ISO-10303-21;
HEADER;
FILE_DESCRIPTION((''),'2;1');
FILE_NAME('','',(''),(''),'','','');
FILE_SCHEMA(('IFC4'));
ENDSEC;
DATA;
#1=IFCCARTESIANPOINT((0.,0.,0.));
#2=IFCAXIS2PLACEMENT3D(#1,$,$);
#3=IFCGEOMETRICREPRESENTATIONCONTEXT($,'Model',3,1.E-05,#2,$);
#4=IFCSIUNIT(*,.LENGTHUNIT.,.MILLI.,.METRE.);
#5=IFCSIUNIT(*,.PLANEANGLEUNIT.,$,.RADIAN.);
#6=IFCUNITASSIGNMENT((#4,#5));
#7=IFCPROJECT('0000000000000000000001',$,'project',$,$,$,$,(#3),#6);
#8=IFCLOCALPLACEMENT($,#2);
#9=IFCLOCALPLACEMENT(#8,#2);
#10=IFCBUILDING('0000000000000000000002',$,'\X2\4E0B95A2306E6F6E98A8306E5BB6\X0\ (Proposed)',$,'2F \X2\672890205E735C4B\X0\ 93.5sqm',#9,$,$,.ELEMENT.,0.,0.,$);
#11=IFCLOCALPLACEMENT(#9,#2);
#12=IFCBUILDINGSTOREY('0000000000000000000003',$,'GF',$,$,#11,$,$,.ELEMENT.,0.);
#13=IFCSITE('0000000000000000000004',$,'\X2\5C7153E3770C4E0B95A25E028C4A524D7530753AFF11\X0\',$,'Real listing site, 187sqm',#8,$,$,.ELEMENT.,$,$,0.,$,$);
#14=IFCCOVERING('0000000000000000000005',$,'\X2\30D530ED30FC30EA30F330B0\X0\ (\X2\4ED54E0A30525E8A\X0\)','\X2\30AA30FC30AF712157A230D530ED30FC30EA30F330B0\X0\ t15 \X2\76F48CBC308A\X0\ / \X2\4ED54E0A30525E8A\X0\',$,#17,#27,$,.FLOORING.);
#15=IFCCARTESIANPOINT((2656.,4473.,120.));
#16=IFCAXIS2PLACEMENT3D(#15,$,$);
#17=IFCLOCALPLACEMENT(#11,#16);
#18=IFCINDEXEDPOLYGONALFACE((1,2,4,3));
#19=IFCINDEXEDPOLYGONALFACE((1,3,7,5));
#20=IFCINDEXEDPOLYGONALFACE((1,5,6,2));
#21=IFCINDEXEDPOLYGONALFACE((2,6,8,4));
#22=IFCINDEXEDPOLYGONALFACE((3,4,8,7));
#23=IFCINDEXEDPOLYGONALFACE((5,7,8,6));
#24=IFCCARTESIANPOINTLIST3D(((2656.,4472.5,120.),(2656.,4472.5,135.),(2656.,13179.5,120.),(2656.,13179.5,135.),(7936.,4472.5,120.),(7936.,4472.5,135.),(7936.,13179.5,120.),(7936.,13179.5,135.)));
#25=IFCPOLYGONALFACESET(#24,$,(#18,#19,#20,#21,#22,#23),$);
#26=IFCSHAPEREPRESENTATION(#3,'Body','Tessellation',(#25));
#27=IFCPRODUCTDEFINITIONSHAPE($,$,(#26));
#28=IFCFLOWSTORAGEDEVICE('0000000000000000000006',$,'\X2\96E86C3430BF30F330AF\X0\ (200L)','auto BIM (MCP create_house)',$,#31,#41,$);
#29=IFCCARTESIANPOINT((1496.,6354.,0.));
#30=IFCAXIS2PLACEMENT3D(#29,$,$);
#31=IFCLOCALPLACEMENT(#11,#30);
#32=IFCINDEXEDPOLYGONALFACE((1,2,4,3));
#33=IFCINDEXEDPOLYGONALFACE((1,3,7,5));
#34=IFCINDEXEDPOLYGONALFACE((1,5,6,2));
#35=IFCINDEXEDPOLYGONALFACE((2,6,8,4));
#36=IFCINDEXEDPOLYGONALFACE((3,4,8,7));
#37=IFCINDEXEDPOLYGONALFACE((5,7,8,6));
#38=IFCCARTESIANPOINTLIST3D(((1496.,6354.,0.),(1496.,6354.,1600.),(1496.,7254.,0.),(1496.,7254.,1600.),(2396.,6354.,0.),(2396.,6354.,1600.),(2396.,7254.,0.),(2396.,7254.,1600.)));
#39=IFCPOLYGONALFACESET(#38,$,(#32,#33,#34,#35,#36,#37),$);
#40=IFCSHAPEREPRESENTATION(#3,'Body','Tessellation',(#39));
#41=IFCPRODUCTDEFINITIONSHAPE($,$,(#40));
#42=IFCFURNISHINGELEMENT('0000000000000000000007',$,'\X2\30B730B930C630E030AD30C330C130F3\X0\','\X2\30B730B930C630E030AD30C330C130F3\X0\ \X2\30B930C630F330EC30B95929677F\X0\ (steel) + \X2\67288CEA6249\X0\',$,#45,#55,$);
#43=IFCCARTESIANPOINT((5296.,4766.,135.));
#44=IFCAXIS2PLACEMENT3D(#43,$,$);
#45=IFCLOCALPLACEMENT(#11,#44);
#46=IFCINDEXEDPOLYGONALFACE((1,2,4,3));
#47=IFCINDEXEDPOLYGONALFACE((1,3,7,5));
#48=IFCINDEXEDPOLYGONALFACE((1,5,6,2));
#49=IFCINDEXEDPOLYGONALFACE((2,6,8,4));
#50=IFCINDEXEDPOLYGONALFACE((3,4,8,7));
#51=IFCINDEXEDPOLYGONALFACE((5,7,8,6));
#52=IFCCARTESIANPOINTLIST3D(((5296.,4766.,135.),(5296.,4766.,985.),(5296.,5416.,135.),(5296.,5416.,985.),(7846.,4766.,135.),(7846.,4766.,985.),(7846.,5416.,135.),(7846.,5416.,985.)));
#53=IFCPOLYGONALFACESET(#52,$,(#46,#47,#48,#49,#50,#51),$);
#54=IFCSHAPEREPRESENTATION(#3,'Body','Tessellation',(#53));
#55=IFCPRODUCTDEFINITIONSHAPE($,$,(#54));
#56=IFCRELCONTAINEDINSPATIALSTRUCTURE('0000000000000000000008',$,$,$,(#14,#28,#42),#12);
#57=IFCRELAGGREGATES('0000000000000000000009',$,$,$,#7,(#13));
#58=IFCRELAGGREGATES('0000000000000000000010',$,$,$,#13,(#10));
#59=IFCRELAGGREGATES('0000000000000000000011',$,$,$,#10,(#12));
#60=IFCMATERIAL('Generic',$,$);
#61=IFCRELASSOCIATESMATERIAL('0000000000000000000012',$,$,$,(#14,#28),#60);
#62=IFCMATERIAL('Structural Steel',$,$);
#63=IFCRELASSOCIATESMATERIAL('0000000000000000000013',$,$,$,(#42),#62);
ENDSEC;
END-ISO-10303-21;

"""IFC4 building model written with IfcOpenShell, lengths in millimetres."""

from ifc_helpers import new_model, si_unit, frame, frame_2d, origin, place, context, project, spatial, rectangle, extrude, material, element, save


model = new_model("IFC4")

# Units and contexts
model_context = context("Model", 3, precision=1e-05, world=origin())
ifc_project = project(units=[si_unit("LENGTHUNIT", "METRE", prefix="MILLI"), si_unit("PLANEANGLEUNIT", "RADIAN")], contexts=[model_context])

# Site, building, storey
site_placement = place(None, origin())
site = spatial("IfcSite", under=ifc_project, at=site_placement, Name="山口県下関市豊前田町１", ObjectType="Real listing site, 187sqm", CompositionType="ELEMENT", RefElevation=0.0)
building_placement = place(site_placement, origin())
building = spatial("IfcBuilding", under=site, at=building_placement, Name="下関の潮風の家 (Proposed)", ObjectType="2F 木造平屋 93.5sqm", CompositionType="ELEMENT", ElevationOfRefHeight=0.0, ElevationOfTerrain=0.0)
storey_placement = place(building_placement, origin())
storey = spatial("IfcBuildingStorey", under=building, at=storey_placement, Name="GF", CompositionType="ELEMENT", Elevation=0.0)

# Covering
ifc_material_1 = material(Name="Generic")
covering_placement = place(storey_placement, frame((2656.0, 4473.0, 120.0)))
element("IfcCovering", 1, at=covering_placement, inside=storey, material=ifc_material_1, Name="フローリング (仕上げ床)", Description="オーク無垢フローリング t15 直貼り / 仕上げ床", PredefinedType="FLOORING", context=model_context, shape_type="SweptSolid", body=[
    extrude(rectangle(XDim=5280.0, YDim=8707.0, at=frame_2d((2640.0, 4353.0))), frame((2656.0, 4473.0, 120.0)), (0.0, 0.0, 1.0), 15.0),
])

# Flow storage device
flow_storage_device_placement = place(storey_placement, frame((1496.0, 6354.0, 0.0)))
element("IfcFlowStorageDevice", 2, at=flow_storage_device_placement, inside=storey, material=ifc_material_1, Name="雨水タンク (200L)", Description="auto BIM (MCP create_house)", context=model_context, shape_type="SweptSolid", body=[
    extrude(rectangle(XDim=900.0, YDim=900.0, at=frame_2d((450.0, 450.0))), frame((1496.0, 6354.0, 0.0)), (0.0, 0.0, 1.0), 1600.0),
])

# Furnishing element
ifc_material_2 = material(Name="Structural Steel")
furnishing_placement = place(storey_placement, frame((5296.0, 4766.0, 135.0)))
element("IfcFurnishingElement", 3, at=furnishing_placement, inside=storey, material=ifc_material_2, Name="システムキッチン", Description="システムキッチン ステンレス天板 (steel) + 木質扉", context=model_context, shape_type="SweptSolid", body=[
    extrude(rectangle(XDim=2550.0, YDim=650.0, at=frame_2d((1275.0, 325.0))), frame((5296.0, 4766.0, 135.0)), (0.0, 0.0, 1.0), 850.0),
])

save(model, "model.ifc")
